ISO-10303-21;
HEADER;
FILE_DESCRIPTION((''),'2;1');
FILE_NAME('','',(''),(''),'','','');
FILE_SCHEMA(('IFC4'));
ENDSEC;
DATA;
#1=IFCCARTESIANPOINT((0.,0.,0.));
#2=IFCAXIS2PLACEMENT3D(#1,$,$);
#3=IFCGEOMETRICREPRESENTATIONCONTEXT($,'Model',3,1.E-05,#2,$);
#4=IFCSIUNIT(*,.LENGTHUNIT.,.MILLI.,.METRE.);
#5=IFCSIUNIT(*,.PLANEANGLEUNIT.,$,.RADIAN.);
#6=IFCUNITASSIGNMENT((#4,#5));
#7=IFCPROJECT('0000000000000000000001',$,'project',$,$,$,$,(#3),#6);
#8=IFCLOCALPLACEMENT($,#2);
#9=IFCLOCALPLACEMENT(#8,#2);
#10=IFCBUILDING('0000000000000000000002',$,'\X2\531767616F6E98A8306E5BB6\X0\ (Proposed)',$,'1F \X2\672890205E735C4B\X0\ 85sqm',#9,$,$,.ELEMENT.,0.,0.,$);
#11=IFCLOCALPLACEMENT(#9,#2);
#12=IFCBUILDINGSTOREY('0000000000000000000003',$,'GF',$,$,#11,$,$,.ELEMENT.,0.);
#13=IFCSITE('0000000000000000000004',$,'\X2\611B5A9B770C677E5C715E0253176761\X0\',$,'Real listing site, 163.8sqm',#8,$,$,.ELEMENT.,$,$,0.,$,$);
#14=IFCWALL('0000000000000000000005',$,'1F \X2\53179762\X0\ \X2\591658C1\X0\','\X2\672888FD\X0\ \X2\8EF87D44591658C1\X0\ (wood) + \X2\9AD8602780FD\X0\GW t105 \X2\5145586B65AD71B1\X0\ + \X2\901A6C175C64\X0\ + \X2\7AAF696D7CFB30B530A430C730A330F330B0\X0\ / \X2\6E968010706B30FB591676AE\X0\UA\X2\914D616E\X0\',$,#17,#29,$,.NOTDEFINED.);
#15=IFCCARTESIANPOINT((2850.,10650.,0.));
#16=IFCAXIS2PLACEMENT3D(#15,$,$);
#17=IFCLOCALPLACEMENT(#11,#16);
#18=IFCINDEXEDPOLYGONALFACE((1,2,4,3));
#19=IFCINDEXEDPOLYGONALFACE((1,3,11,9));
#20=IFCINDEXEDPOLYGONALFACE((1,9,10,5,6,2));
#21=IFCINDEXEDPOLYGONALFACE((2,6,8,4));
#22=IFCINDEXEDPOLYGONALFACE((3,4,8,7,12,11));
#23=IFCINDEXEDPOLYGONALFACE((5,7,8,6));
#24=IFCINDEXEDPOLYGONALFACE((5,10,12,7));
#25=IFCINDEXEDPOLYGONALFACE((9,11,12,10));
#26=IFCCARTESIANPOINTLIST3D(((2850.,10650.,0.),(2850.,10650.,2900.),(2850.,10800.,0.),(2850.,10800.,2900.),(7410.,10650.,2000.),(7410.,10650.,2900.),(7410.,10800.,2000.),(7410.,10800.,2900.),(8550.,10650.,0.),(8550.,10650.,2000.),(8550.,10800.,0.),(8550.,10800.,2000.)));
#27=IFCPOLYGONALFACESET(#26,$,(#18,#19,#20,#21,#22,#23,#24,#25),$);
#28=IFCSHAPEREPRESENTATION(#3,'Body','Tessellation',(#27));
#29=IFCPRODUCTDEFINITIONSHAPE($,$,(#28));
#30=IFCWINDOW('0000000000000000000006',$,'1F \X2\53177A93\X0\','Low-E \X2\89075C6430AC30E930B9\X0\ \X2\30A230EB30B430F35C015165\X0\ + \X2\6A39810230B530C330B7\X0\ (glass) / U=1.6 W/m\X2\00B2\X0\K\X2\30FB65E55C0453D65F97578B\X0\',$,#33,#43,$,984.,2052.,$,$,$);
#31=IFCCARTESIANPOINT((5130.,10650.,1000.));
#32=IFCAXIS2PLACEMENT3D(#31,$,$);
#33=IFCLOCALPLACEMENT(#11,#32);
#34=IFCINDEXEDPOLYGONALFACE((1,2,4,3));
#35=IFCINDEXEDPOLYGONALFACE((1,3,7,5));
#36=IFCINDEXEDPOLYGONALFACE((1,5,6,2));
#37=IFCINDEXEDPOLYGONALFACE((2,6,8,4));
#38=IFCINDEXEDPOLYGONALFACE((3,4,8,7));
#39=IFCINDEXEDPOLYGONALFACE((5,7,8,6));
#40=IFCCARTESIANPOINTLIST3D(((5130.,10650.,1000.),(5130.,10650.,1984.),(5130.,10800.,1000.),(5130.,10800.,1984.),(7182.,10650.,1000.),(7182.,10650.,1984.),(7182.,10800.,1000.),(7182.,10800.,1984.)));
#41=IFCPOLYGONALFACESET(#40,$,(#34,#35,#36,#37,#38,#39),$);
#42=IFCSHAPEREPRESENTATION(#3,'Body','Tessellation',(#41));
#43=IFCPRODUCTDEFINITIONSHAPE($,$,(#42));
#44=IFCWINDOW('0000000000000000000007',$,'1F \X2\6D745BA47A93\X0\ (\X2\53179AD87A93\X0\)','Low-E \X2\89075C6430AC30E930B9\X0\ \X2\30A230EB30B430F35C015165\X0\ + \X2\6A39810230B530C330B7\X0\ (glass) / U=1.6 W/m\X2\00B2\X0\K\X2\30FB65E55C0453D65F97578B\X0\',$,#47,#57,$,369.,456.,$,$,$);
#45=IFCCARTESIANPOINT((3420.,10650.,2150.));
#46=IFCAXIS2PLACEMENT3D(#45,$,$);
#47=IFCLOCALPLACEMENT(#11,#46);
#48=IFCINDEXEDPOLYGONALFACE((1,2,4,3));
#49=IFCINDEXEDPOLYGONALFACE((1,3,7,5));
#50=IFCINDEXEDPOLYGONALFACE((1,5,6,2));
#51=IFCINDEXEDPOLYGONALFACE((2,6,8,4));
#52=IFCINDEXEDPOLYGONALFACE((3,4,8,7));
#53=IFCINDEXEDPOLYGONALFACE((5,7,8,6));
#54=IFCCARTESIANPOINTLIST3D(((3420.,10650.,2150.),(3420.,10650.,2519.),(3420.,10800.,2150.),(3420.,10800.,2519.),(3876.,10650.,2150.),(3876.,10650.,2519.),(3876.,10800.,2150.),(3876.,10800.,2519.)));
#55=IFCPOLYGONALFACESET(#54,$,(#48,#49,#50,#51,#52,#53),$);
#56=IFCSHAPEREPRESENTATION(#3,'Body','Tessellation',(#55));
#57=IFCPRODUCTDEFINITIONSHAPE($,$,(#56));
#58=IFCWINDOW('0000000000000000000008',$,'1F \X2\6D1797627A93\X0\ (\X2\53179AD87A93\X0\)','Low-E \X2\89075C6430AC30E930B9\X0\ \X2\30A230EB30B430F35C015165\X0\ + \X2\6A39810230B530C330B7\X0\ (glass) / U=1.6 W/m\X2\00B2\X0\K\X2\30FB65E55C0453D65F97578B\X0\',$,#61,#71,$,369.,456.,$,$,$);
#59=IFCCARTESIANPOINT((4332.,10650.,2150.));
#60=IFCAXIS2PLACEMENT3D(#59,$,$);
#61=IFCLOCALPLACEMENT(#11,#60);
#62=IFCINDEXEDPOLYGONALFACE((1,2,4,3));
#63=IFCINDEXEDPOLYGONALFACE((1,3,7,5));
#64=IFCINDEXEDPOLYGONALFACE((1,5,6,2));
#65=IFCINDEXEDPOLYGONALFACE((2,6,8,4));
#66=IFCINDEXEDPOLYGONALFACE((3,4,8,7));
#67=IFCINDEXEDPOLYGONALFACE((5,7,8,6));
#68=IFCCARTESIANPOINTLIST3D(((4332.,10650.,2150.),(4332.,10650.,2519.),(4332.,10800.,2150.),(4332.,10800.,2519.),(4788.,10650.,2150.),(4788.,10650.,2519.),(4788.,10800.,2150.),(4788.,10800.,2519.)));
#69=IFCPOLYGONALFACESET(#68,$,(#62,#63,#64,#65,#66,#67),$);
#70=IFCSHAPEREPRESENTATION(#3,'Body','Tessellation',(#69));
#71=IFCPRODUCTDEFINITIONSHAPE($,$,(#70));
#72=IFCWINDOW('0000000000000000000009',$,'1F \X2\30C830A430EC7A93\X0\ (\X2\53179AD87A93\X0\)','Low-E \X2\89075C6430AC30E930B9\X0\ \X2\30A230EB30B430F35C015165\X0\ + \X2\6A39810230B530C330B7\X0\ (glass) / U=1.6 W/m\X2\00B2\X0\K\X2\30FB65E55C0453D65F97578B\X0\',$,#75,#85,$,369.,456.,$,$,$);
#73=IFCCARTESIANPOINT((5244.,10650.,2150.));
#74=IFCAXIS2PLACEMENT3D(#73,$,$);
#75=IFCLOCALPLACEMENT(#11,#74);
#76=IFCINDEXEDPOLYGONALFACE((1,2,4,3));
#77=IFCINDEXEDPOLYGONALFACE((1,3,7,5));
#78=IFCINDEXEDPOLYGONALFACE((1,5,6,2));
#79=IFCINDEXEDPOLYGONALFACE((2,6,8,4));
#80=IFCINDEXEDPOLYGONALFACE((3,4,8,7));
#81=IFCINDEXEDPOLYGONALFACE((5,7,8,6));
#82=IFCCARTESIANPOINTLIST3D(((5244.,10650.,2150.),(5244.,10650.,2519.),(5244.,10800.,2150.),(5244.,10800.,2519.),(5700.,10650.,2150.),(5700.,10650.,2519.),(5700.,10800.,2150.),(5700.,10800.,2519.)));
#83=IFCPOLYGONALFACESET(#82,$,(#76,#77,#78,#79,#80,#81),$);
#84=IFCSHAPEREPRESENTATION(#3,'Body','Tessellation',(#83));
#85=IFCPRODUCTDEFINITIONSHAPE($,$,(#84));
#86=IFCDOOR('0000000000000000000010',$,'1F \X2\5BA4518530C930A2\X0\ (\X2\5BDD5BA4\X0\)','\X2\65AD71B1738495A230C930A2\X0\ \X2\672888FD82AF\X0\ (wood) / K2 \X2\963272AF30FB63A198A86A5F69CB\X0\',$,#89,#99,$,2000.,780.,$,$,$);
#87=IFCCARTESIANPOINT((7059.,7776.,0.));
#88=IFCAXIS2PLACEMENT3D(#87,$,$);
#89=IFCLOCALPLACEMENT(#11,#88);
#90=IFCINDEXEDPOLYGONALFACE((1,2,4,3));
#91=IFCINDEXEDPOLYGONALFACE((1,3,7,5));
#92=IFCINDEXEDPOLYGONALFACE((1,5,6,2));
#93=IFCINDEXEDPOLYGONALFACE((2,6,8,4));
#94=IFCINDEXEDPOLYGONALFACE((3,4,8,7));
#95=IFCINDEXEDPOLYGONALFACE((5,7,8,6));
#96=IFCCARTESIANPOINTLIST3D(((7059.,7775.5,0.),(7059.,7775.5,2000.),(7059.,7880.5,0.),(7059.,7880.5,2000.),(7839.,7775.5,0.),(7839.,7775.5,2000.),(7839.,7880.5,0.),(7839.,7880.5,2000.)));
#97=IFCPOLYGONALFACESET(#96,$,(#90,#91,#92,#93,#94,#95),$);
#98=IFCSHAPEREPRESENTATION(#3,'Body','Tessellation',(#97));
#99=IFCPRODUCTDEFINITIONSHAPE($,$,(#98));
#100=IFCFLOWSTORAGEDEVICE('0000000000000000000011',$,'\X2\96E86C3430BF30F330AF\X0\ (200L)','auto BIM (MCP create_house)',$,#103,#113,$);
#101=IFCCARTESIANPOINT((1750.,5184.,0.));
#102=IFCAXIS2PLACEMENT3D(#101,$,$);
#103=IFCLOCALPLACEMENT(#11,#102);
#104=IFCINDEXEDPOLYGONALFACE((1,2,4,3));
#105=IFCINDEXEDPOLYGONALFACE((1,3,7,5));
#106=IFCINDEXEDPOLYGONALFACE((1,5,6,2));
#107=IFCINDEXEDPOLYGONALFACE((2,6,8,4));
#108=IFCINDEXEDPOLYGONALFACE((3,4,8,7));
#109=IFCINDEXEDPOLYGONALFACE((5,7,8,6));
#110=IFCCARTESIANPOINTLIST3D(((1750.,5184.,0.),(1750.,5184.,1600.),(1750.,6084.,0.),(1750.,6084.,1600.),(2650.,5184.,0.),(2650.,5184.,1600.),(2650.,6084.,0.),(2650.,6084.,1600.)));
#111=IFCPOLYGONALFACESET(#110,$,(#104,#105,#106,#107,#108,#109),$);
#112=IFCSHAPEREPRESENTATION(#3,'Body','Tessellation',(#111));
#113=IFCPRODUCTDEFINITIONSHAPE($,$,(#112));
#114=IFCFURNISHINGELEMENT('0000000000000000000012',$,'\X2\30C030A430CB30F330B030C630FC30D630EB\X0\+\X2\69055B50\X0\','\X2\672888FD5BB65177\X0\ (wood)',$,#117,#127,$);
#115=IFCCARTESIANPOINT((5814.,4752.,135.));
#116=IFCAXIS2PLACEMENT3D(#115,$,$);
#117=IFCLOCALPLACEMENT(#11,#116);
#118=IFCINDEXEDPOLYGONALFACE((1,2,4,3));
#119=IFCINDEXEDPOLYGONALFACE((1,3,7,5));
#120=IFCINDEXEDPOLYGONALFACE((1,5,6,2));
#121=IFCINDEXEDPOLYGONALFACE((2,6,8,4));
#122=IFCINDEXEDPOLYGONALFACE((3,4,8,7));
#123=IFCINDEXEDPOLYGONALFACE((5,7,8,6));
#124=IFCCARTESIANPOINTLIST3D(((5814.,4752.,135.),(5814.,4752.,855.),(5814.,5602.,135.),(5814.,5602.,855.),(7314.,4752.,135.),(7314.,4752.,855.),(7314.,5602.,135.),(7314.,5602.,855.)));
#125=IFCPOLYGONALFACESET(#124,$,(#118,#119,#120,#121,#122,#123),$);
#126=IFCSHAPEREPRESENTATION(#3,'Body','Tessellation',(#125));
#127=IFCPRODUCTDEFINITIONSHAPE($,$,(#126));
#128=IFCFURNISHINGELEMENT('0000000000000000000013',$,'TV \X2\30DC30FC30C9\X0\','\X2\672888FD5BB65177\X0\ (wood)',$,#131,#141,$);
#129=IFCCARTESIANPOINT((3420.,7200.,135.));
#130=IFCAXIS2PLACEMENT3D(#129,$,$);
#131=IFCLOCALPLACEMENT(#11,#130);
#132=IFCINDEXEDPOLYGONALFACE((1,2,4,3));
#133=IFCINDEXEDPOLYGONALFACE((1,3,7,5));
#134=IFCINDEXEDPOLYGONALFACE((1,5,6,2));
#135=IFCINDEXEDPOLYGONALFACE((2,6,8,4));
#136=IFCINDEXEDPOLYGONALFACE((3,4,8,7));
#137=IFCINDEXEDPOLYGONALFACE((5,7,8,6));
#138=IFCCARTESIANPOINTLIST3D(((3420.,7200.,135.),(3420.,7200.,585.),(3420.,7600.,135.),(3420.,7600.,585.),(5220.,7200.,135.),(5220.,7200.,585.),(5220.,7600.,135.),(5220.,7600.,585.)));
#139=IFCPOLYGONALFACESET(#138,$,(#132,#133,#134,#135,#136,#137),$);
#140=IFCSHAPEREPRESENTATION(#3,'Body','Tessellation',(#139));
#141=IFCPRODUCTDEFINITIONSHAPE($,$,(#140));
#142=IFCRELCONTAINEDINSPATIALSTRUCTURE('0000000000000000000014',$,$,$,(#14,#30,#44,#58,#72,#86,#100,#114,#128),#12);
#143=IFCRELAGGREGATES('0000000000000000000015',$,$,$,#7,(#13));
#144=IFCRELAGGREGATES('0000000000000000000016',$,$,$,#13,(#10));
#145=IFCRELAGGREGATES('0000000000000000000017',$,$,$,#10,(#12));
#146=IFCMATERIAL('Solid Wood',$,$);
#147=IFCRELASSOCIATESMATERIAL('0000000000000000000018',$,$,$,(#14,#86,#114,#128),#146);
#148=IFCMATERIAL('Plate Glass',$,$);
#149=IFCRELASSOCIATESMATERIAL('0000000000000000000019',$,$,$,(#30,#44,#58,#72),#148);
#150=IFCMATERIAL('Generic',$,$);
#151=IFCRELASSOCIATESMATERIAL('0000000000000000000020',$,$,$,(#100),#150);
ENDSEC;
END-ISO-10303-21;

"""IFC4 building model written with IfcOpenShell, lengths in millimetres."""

from ifc_helpers import new_model, si_unit, frame, frame_2d, origin, place, context, project, spatial, rectangle, extrude, material, element, fill, save


model = new_model("IFC4")

# Units and contexts
model_context = context("Model", 3, precision=1e-05, world=origin())
ifc_project = project(units=[si_unit("LENGTHUNIT", "METRE", prefix="MILLI"), si_unit("PLANEANGLEUNIT", "RADIAN")], contexts=[model_context])

# Site, building, storey
site_placement = place(None, origin())
site = spatial("IfcSite", under=ifc_project, at=site_placement, Name="愛媛県松山市北条", ObjectType="Real listing site, 163.8sqm", CompositionType="ELEMENT", RefElevation=0.0)
building_placement = place(site_placement, origin())
building = spatial("IfcBuilding", under=site, at=building_placement, Name="北条潮風の家 (Proposed)", ObjectType="1F 木造平屋 85sqm", CompositionType="ELEMENT", ElevationOfRefHeight=0.0, ElevationOfTerrain=0.0)
storey_placement = place(building_placement, origin())
storey = spatial("IfcBuildingStorey", under=building, at=storey_placement, Name="GF", CompositionType="ELEMENT", Elevation=0.0)

# Wall, openings, windows
ifc_material_1 = material(Name="Solid Wood")
wall_1_placement = place(storey_placement, frame((2850.0, 10650.0, 0.0)))
wall_1 = element("IfcWall", 1, at=wall_1_placement, inside=storey, material=ifc_material_1, Name="1F 北面 外壁", Description="木製 軸組外壁 (wood) + 高性能GW t105 充填断熱 + 通気層 + 窯業系サイディング / 準耐火・外皮UA配慮", PredefinedType="NOTDEFINED", context=model_context, shape_type="SweptSolid", body=[
    extrude(rectangle(XDim=5700.0, YDim=150.0, at=frame_2d((2850.0, 75.0))), frame((2850.0, 10650.0, 0.0)), (0.0, 0.0, 1.0), 2900.0),
])
opening_1_placement = place(storey_placement, frame((5130.0, 10650.0, 1000.0)))
opening_1 = element("IfcOpeningElement", 2, at=opening_1_placement, cuts=wall_1, PredefinedType="NOTDEFINED", context=model_context, shape_type="SweptSolid", body=[
    extrude(rectangle(XDim=2052.0, YDim=150.0, at=frame_2d((1026.0, 75.0))), frame((5130.0, 10650.0, 1000.0)), (0.0, 0.0, 1.0), 984.0),
])
opening_2_placement = place(storey_placement, frame((3420.0, 10650.0, 2150.0)))
opening_2 = element("IfcOpeningElement", 3, at=opening_2_placement, cuts=wall_1, PredefinedType="NOTDEFINED", context=model_context, shape_type="SweptSolid", body=[
    extrude(rectangle(XDim=456.0, YDim=150.0, at=frame_2d((228.0, 75.0))), frame((3420.0, 10650.0, 2150.0)), (0.0, 0.0, 1.0), 369.0),
])
opening_3_placement = place(storey_placement, frame((4332.0, 10650.0, 2150.0)))
opening_3 = element("IfcOpeningElement", 4, at=opening_3_placement, cuts=wall_1, PredefinedType="NOTDEFINED", context=model_context, shape_type="SweptSolid", body=[
    extrude(rectangle(XDim=456.0, YDim=150.0, at=frame_2d((228.0, 75.0))), frame((4332.0, 10650.0, 2150.0)), (0.0, 0.0, 1.0), 369.0),
])
opening_4_placement = place(storey_placement, frame((5244.0, 10650.0, 2150.0)))
opening_4 = element("IfcOpeningElement", 5, at=opening_4_placement, cuts=wall_1, PredefinedType="NOTDEFINED", context=model_context, shape_type="SweptSolid", body=[
    extrude(rectangle(XDim=456.0, YDim=150.0, at=frame_2d((228.0, 75.0))), frame((5244.0, 10650.0, 2150.0)), (0.0, 0.0, 1.0), 369.0),
])
ifc_material_2 = material(Name="Plate Glass")
window_1_placement = place(storey_placement, frame((5130.0, 10650.0, 1000.0)))
window_1 = element("IfcWindow", 6, at=window_1_placement, inside=storey, material=ifc_material_2, Name="1F 北窓", Description="Low-E 複層ガラス アルゴン封入 + 樹脂サッシ (glass) / U=1.6 W/m²K・日射取得型", OverallHeight=984.0, OverallWidth=2052.0, context=model_context, shape_type="SweptSolid", body=[
    extrude(rectangle(XDim=2052.0, YDim=150.0, at=frame_2d((1026.0, 75.0))), frame((5130.0, 10650.0, 1000.0)), (0.0, 0.0, 1.0), 984.0),
])
fill(opening_1, window_1)
window_2_placement = place(storey_placement, frame((3420.0, 10650.0, 2150.0)))
window_2 = element("IfcWindow", 7, at=window_2_placement, inside=storey, material=ifc_material_2, Name="1F 浴室窓 (北高窓)", Description="Low-E 複層ガラス アルゴン封入 + 樹脂サッシ (glass) / U=1.6 W/m²K・日射取得型", OverallHeight=369.0, OverallWidth=456.0, context=model_context, shape_type="SweptSolid", body=[
    extrude(rectangle(XDim=456.0, YDim=150.0, at=frame_2d((228.0, 75.0))), frame((3420.0, 10650.0, 2150.0)), (0.0, 0.0, 1.0), 369.0),
])
fill(opening_2, window_2)
window_3_placement = place(storey_placement, frame((4332.0, 10650.0, 2150.0)))
window_3 = element("IfcWindow", 8, at=window_3_placement, inside=storey, material=ifc_material_2, Name="1F 洗面窓 (北高窓)", Description="Low-E 複層ガラス アルゴン封入 + 樹脂サッシ (glass) / U=1.6 W/m²K・日射取得型", OverallHeight=369.0, OverallWidth=456.0, context=model_context, shape_type="SweptSolid", body=[
    extrude(rectangle(XDim=456.0, YDim=150.0, at=frame_2d((228.0, 75.0))), frame((4332.0, 10650.0, 2150.0)), (0.0, 0.0, 1.0), 369.0),
])
fill(opening_3, window_3)
window_4_placement = place(storey_placement, frame((5244.0, 10650.0, 2150.0)))
window_4 = element("IfcWindow", 9, at=window_4_placement, inside=storey, material=ifc_material_2, Name="1F トイレ窓 (北高窓)", Description="Low-E 複層ガラス アルゴン封入 + 樹脂サッシ (glass) / U=1.6 W/m²K・日射取得型", OverallHeight=369.0, OverallWidth=456.0, context=model_context, shape_type="SweptSolid", body=[
    extrude(rectangle(XDim=456.0, YDim=150.0, at=frame_2d((228.0, 75.0))), frame((5244.0, 10650.0, 2150.0)), (0.0, 0.0, 1.0), 369.0),
])
fill(opening_4, window_4)

# Door
door_1_placement = place(storey_placement, frame((7059.0, 7776.0, 0.0)))
element("IfcDoor", 10, at=door_1_placement, inside=storey, material=ifc_material_1, Name="1F 室内ドア (寝室)", Description="断熱玄関ドア 木製芯 (wood) / K2 防犯・採風機構", OverallHeight=2000.0, OverallWidth=780.0, context=model_context, shape_type="SweptSolid", body=[
    extrude(rectangle(XDim=780.0, YDim=105.0, at=frame_2d((390.0, 52.0))), frame((7059.0, 7776.0, 0.0)), (0.0, 0.0, 1.0), 2000.0),
])

# Flow storage device
ifc_material_3 = material(Name="Generic")
flow_storage_device_placement = place(storey_placement, frame((1750.0, 5184.0, 0.0)))
element("IfcFlowStorageDevice", 11, at=flow_storage_device_placement, inside=storey, material=ifc_material_3, Name="雨水タンク (200L)", Description="auto BIM (MCP create_house)", context=model_context, shape_type="SweptSolid", body=[
    extrude(rectangle(XDim=900.0, YDim=900.0, at=frame_2d((450.0, 450.0))), frame((1750.0, 5184.0, 0.0)), (0.0, 0.0, 1.0), 1600.0),
])

# Furnishing elements
furnishing_1_placement = place(storey_placement, frame((5814.0, 4752.0, 135.0)))
element("IfcFurnishingElement", 12, at=furnishing_1_placement, inside=storey, material=ifc_material_1, Name="ダイニングテーブル+椅子", Description="木製家具 (wood)", context=model_context, shape_type="SweptSolid", body=[
    extrude(rectangle(XDim=1500.0, YDim=850.0, at=frame_2d((750.0, 425.0))), frame((5814.0, 4752.0, 135.0)), (0.0, 0.0, 1.0), 720.0),
])
furnishing_2_placement = place(storey_placement, frame((3420.0, 7200.0, 135.0)))
element("IfcFurnishingElement", 13, at=furnishing_2_placement, inside=storey, material=ifc_material_1, Name="TV ボード", Description="木製家具 (wood)", context=model_context, shape_type="SweptSolid", body=[
    extrude(rectangle(XDim=1800.0, YDim=400.0, at=frame_2d((900.0, 200.0))), frame((3420.0, 7200.0, 135.0)), (0.0, 0.0, 1.0), 450.0),
])

save(model, "model.ifc")
